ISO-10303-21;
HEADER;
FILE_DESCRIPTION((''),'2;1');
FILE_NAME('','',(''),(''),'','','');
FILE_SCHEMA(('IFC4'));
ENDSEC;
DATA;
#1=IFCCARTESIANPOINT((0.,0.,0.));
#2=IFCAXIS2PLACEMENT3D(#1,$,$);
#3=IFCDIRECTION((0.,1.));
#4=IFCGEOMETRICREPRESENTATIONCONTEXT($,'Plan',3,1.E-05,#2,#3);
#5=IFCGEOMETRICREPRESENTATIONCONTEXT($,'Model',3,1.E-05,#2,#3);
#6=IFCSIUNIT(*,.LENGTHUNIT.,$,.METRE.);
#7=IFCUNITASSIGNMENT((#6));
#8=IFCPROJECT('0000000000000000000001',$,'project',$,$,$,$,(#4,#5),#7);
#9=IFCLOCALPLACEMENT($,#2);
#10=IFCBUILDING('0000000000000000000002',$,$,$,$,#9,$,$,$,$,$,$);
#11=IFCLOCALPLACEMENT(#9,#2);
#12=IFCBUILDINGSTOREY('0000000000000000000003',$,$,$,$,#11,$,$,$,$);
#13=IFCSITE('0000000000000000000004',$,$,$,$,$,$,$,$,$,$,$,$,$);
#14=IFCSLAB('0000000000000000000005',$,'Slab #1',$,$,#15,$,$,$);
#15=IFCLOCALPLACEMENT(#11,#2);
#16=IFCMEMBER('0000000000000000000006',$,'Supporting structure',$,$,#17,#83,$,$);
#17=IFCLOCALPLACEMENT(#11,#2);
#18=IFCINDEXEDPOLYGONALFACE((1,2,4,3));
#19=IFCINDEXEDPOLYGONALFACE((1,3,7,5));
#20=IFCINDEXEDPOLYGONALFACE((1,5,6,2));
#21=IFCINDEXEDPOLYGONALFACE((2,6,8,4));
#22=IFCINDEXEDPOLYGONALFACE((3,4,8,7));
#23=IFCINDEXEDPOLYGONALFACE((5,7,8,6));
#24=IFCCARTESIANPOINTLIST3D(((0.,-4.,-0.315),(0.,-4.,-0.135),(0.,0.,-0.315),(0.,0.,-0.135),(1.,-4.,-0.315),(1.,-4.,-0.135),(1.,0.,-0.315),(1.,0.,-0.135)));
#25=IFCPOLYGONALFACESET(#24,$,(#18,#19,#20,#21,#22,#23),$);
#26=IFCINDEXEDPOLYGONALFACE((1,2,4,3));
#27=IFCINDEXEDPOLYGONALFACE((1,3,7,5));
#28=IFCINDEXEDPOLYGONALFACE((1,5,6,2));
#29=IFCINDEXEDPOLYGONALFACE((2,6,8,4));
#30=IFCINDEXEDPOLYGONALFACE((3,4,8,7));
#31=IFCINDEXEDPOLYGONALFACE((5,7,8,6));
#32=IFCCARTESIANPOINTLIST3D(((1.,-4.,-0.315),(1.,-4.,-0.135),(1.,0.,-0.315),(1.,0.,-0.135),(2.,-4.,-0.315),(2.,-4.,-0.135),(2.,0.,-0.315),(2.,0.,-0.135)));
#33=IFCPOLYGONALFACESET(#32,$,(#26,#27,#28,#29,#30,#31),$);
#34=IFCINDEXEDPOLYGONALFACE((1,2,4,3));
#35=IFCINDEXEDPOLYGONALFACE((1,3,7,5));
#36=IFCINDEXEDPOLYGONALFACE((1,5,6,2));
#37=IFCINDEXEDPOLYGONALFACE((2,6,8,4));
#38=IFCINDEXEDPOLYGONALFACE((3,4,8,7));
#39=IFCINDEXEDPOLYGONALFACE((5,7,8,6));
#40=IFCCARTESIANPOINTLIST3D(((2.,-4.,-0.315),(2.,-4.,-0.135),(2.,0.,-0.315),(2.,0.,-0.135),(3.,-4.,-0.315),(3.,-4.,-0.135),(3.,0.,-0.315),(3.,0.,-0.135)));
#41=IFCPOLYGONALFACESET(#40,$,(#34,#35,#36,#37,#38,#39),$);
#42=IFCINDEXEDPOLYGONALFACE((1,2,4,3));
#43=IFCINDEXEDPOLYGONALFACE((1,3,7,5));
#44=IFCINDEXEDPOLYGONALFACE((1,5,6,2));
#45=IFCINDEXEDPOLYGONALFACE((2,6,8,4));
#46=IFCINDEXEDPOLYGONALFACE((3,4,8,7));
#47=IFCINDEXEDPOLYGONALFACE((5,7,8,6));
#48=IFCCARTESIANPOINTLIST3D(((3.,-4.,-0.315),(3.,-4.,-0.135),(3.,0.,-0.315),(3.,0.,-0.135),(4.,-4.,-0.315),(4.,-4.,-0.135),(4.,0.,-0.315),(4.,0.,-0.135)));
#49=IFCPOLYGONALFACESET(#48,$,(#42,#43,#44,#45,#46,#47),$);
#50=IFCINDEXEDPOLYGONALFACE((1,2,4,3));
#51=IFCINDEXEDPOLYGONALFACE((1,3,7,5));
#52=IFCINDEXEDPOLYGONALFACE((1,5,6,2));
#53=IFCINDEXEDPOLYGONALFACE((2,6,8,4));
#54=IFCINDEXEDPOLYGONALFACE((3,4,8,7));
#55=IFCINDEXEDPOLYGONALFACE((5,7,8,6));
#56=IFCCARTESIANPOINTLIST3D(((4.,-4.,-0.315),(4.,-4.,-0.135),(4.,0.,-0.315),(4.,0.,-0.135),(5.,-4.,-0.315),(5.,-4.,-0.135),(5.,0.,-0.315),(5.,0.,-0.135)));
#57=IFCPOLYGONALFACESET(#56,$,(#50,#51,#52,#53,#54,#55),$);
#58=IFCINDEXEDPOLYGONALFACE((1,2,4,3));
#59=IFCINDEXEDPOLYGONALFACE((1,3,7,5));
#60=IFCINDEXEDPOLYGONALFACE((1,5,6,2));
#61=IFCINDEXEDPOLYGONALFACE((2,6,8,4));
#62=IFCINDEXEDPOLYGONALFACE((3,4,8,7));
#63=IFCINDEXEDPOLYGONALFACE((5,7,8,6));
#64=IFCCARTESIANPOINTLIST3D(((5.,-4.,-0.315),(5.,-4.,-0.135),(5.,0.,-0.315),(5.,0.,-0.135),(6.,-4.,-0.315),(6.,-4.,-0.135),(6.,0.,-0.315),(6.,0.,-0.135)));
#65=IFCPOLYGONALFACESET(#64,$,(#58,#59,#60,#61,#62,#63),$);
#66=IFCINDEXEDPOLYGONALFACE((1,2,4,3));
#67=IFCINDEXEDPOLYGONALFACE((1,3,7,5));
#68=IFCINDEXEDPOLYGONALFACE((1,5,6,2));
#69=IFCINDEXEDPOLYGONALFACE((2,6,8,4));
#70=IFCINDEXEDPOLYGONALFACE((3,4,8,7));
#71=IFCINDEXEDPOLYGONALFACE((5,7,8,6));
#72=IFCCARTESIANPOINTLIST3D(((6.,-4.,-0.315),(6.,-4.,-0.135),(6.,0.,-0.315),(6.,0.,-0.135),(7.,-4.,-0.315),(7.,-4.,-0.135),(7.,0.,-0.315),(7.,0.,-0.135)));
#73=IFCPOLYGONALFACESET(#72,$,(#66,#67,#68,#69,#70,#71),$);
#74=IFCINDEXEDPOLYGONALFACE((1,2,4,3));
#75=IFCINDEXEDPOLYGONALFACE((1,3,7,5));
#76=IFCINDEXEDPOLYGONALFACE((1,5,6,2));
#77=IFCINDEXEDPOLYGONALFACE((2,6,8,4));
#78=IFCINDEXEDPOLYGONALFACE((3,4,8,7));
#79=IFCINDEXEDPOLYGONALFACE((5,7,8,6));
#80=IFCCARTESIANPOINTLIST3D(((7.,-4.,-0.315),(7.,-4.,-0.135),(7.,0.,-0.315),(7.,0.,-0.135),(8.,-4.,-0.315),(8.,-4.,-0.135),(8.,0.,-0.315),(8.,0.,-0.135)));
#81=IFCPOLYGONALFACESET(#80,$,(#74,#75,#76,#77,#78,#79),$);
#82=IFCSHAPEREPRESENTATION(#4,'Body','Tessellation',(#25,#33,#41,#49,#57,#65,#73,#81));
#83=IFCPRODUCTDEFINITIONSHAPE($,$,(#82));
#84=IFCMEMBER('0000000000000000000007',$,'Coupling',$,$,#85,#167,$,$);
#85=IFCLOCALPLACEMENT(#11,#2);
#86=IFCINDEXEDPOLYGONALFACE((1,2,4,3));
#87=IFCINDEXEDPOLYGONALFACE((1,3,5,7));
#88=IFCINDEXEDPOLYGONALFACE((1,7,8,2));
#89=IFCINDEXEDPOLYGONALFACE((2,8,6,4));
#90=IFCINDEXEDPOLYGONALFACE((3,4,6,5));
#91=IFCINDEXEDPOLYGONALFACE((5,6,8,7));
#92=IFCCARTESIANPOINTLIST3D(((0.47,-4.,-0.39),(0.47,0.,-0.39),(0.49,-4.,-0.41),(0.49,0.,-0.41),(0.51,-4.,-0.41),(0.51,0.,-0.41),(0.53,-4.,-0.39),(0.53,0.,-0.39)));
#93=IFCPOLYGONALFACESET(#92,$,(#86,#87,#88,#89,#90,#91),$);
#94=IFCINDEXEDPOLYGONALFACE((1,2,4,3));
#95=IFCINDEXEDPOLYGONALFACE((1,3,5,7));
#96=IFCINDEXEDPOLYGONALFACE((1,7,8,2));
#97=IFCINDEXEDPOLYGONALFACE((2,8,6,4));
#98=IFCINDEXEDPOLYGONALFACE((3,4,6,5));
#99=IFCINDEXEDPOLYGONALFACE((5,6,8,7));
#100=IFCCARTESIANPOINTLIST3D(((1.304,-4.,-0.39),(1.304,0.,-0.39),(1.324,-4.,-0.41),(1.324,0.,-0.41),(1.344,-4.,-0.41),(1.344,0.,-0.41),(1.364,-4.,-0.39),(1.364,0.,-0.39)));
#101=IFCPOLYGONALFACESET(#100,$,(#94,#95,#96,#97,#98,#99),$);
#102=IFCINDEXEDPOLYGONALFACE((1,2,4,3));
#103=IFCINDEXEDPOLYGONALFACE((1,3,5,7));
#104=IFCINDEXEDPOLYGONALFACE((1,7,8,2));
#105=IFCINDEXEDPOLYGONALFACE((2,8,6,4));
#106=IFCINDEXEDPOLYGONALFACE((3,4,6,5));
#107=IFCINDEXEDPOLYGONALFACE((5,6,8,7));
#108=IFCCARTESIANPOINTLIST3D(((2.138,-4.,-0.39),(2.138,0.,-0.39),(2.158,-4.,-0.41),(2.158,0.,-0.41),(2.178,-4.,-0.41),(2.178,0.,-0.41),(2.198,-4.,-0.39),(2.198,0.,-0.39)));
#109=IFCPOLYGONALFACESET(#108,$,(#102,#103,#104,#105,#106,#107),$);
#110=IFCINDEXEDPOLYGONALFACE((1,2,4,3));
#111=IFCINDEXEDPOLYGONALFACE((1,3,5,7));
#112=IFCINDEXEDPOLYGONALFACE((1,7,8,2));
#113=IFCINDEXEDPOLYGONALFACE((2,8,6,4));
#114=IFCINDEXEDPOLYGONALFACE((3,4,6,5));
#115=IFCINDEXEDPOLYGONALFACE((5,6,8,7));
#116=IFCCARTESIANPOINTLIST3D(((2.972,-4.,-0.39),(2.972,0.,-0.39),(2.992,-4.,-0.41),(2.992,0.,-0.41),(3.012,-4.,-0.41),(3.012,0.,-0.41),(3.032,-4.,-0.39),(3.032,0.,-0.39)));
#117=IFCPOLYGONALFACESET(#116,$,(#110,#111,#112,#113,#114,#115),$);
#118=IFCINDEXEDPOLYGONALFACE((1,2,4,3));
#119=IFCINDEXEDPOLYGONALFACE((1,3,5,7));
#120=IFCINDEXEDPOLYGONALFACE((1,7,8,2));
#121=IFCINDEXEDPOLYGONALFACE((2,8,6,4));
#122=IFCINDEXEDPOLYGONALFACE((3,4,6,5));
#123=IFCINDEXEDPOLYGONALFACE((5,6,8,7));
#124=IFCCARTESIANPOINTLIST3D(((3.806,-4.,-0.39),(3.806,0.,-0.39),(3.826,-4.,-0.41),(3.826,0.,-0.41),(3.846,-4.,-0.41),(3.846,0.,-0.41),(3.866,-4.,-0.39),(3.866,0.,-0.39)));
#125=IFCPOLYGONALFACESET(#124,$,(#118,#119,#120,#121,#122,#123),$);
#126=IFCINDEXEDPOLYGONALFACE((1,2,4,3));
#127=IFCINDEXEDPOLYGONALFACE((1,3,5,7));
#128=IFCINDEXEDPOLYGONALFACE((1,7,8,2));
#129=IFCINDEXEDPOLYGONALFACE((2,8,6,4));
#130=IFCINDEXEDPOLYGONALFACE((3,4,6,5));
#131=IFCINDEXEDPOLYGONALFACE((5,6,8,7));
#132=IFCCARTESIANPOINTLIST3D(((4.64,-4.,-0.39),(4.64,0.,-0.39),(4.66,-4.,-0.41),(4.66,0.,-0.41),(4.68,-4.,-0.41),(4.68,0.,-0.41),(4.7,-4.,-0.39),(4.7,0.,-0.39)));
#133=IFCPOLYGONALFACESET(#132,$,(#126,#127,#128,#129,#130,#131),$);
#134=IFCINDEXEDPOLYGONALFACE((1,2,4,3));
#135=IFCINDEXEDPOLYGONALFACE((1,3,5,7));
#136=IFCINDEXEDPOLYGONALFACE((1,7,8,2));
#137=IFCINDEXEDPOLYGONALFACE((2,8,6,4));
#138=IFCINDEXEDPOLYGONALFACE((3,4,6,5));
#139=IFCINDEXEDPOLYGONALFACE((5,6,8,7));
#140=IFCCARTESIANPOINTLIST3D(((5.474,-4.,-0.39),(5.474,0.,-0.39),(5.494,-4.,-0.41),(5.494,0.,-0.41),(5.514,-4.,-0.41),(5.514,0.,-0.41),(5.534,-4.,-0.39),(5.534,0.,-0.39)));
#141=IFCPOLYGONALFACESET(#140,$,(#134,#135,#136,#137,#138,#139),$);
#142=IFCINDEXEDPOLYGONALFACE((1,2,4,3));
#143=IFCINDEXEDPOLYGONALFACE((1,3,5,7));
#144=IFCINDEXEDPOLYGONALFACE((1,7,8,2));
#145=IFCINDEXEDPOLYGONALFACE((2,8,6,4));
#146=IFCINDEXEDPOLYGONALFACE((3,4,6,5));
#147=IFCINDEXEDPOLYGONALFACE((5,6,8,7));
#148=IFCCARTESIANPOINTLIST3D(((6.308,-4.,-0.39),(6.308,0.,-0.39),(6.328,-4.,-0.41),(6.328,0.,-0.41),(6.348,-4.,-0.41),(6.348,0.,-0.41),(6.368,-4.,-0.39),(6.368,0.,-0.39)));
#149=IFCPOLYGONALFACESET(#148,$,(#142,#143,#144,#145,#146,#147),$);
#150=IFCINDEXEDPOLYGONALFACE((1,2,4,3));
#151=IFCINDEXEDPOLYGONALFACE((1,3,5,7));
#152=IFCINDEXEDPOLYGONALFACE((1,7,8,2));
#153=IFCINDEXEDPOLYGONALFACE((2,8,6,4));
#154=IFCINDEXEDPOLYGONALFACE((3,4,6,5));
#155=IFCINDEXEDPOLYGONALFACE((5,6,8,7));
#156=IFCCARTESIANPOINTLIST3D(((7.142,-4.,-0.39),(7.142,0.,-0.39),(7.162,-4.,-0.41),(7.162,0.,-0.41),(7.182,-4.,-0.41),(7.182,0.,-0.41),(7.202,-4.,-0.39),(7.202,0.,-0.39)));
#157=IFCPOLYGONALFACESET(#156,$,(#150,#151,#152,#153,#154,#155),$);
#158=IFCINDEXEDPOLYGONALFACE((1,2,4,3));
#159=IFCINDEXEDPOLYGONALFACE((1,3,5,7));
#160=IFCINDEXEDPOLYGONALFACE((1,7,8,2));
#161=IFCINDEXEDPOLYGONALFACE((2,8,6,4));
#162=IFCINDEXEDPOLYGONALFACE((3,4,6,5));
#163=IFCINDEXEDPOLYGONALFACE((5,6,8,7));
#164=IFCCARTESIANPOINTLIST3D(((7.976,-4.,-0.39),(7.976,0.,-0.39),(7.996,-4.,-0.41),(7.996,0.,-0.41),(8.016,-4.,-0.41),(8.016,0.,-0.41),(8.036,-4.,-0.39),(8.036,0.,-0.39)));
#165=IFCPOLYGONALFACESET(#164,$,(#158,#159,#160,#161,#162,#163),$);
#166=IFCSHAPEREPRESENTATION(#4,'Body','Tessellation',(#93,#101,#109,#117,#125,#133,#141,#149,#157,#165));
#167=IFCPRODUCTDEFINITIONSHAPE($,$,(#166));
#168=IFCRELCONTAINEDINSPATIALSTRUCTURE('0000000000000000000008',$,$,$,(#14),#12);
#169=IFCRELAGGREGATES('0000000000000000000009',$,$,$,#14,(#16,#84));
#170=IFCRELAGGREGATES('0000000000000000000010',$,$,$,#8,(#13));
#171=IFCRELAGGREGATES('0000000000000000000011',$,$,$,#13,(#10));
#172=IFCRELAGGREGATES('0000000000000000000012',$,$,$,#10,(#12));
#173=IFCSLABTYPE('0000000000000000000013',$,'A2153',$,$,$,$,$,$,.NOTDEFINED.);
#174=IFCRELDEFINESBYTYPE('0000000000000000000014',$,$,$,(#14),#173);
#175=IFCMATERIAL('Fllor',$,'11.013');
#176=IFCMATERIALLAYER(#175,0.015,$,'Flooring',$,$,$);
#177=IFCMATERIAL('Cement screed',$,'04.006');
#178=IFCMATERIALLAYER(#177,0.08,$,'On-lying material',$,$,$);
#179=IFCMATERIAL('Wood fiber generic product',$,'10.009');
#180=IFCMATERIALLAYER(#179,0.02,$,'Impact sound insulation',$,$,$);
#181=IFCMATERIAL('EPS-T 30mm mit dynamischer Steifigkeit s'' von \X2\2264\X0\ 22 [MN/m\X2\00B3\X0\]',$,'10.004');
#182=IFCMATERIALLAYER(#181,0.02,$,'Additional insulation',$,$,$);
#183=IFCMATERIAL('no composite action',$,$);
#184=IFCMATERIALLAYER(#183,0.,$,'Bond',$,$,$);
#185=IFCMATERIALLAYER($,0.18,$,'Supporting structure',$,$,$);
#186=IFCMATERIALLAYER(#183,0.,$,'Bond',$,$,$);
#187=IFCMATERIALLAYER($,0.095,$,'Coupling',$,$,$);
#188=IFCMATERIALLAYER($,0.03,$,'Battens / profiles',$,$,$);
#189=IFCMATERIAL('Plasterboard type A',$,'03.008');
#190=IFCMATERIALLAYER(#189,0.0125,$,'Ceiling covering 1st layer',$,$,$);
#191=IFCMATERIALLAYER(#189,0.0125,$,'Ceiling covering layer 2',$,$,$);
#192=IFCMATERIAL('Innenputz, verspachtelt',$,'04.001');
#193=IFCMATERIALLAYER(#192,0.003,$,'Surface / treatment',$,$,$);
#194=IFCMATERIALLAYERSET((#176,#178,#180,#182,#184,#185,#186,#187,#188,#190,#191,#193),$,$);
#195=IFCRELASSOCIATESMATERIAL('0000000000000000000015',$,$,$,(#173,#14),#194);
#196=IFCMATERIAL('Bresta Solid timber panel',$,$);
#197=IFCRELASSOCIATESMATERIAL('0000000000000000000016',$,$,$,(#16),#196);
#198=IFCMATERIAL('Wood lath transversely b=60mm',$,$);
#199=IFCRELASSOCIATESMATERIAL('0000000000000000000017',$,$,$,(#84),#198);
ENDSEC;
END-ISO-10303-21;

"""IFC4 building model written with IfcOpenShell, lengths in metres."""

from ifc_helpers import new_model, si_unit, direction, frame, frame_2d, origin, place, context, project, spatial, polyline, rectangle, outline, extrude, material, layer, layer_set, type_object, element, aggregate, save


model = new_model("IFC4")

# Units and contexts
plan_context = context("Plan", 3, precision=1e-05, world=origin(), true_north=direction((0.0, 1.0)))
model_context = context("Model", 3, precision=1e-05, world=origin(), true_north=direction((0.0, 1.0)))
ifc_project = project(units=[si_unit("LENGTHUNIT", "METRE")], contexts=[plan_context, model_context])

# Site, building, storey
site = spatial("IfcSite", under=ifc_project)
building_placement = place(None, origin())
building = spatial("IfcBuilding", under=site, at=building_placement)
storey_placement = place(building_placement, origin())
storey = spatial("IfcBuildingStorey", under=building, at=storey_placement)

# Slab, members
ifc_material_1 = material(Name="Fllor", Category="11.013")
ifc_layer_1 = layer(ifc_material_1, 0.015, Name="Flooring")
ifc_material_2 = material(Name="Cement screed", Category="04.006")
ifc_layer_2 = layer(ifc_material_2, 0.08, Name="On-lying material")
ifc_material_3 = material(Name="Wood fiber generic product", Category="10.009")
ifc_layer_3 = layer(ifc_material_3, 0.02, Name="Impact sound insulation")
ifc_material_4 = material(Name="EPS-T 30mm mit dynamischer Steifigkeit s' von ≤ 22 [MN/m³]", Category="10.004")
ifc_layer_4 = layer(ifc_material_4, 0.02, Name="Additional insulation")
ifc_material_5 = material(Name="no composite action")
ifc_layer_5 = layer(ifc_material_5, 0.0, Name="Bond")
ifc_layer_6 = layer(None, 0.18, Name="Supporting structure")
ifc_layer_7 = layer(ifc_material_5, 0.0, Name="Bond")
ifc_layer_8 = layer(None, 0.095, Name="Coupling")
ifc_layer_9 = layer(None, 0.03, Name="Battens / profiles")
ifc_material_6 = material(Name="Plasterboard type A", Category="03.008")
ifc_layer_10 = layer(ifc_material_6, 0.0125, Name="Ceiling covering 1st layer")
ifc_layer_11 = layer(ifc_material_6, 0.0125, Name="Ceiling covering layer 2")
ifc_material_7 = material(Name="Innenputz, verspachtelt", Category="04.001")
ifc_layer_12 = layer(ifc_material_7, 0.003, Name="Surface / treatment")
ifc_layer_set = layer_set([ifc_layer_1, ifc_layer_2, ifc_layer_3, ifc_layer_4, ifc_layer_5, ifc_layer_6, ifc_layer_7, ifc_layer_8, ifc_layer_9, ifc_layer_10, ifc_layer_11, ifc_layer_12])
slab_type = type_object("IfcSlabType", Name="A2153", PredefinedType="NOTDEFINED", material=ifc_layer_set)
slab_placement = place(None, frame((0.0, 0.0, 0.0), z_axis=(0.0, 0.0, -1.0), x_axis=(1.0, 0.0, 0.0)))
slab = element("IfcSlab", 1, at=slab_placement, inside=storey, type_object=slab_type, material=ifc_layer_set, Name="Slab #1")
ifc_material_8 = material(Name="Bresta Solid timber panel")
member_1_placement = place(slab_placement, origin())
member_1 = element("IfcMember", 2, at=member_1_placement, material=ifc_material_8, Name="Supporting structure", context=plan_context, shape_type="SweptSolid", body=[
    extrude(rectangle(XDim=1.0, YDim=0.18, at=frame_2d((0.5, 0.09), x_axis=(1.0, 0.0))), frame((0.0, 4.0, 0.135), z_axis=(0.0, -1.0, 0.0), x_axis=(1.0, 0.0, 0.0)), (0.0, 0.0, 1.0), 4.0),
    extrude(rectangle(XDim=1.0, YDim=0.18, at=frame_2d((0.5, 0.09), x_axis=(1.0, 0.0))), frame((1.0, 4.0, 0.135), z_axis=(0.0, -1.0, 0.0), x_axis=(1.0, 0.0, 0.0)), (0.0, 0.0, 1.0), 4.0),
    extrude(rectangle(XDim=1.0, YDim=0.18, at=frame_2d((0.5, 0.09), x_axis=(1.0, 0.0))), frame((2.0, 4.0, 0.135), z_axis=(0.0, -1.0, 0.0), x_axis=(1.0, 0.0, 0.0)), (0.0, 0.0, 1.0), 4.0),
    extrude(rectangle(XDim=1.0, YDim=0.18, at=frame_2d((0.5, 0.09), x_axis=(1.0, 0.0))), frame((3.0, 4.0, 0.135), z_axis=(0.0, -1.0, 0.0), x_axis=(1.0, 0.0, 0.0)), (0.0, 0.0, 1.0), 4.0),
    extrude(rectangle(XDim=1.0, YDim=0.18, at=frame_2d((0.5, 0.09), x_axis=(1.0, 0.0))), frame((4.0, 4.0, 0.135), z_axis=(0.0, -1.0, 0.0), x_axis=(1.0, 0.0, 0.0)), (0.0, 0.0, 1.0), 4.0),
    extrude(rectangle(XDim=1.0, YDim=0.18, at=frame_2d((0.5, 0.09), x_axis=(1.0, 0.0))), frame((5.0, 4.0, 0.135), z_axis=(0.0, -1.0, 0.0), x_axis=(1.0, 0.0, 0.0)), (0.0, 0.0, 1.0), 4.0),
    extrude(rectangle(XDim=1.0, YDim=0.18, at=frame_2d((0.5, 0.09), x_axis=(1.0, 0.0))), frame((6.0, 4.0, 0.135), z_axis=(0.0, -1.0, 0.0), x_axis=(1.0, 0.0, 0.0)), (0.0, 0.0, 1.0), 4.0),
    extrude(rectangle(XDim=1.0, YDim=0.18, at=frame_2d((0.5, 0.09), x_axis=(1.0, 0.0))), frame((7.0, 4.0, 0.135), z_axis=(0.0, -1.0, 0.0), x_axis=(1.0, 0.0, 0.0)), (0.0, 0.0, 1.0), 4.0),
])
ifc_material_9 = material(Name="Wood lath transversely b=60mm")
member_2_placement = place(slab_placement, origin())
member_2 = element("IfcMember", 3, at=member_2_placement, material=ifc_material_9, Name="Coupling", context=plan_context, shape_type="SweptSolid", body=[
    extrude(outline(polyline([(0.0, 0.0), (0.06, 0.0), (0.04, 0.02), (0.02, 0.02), (0.0, 0.0)])), frame((0.47, 4.0, 0.39), z_axis=(0.0, -1.0, 0.0), x_axis=(1.0, 0.0, 0.0)), (0.0, 0.0, 1.0), 4.0),
    extrude(outline(polyline([(0.0, 0.0), (0.06, 0.0), (0.04, 0.02), (0.02, 0.02), (0.0, 0.0)])), frame((1.304, 4.0, 0.39), z_axis=(0.0, -1.0, 0.0), x_axis=(1.0, 0.0, 0.0)), (0.0, 0.0, 1.0), 4.0),
    extrude(outline(polyline([(0.0, 0.0), (0.06, 0.0), (0.04, 0.02), (0.02, 0.02), (0.0, 0.0)])), frame((2.138, 4.0, 0.39), z_axis=(0.0, -1.0, 0.0), x_axis=(1.0, 0.0, 0.0)), (0.0, 0.0, 1.0), 4.0),
    extrude(outline(polyline([(0.0, 0.0), (0.06, 0.0), (0.04, 0.02), (0.02, 0.02), (0.0, 0.0)])), frame((2.972, 4.0, 0.39), z_axis=(0.0, -1.0, 0.0), x_axis=(1.0, 0.0, 0.0)), (0.0, 0.0, 1.0), 4.0),
    extrude(outline(polyline([(0.0, 0.0), (0.06, 0.0), (0.04, 0.02), (0.02, 0.02), (0.0, 0.0)])), frame((3.806, 4.0, 0.39), z_axis=(0.0, -1.0, 0.0), x_axis=(1.0, 0.0, 0.0)), (0.0, 0.0, 1.0), 4.0),
    extrude(outline(polyline([(0.0, 0.0), (0.06, 0.0), (0.04, 0.02), (0.02, 0.02), (0.0, 0.0)])), frame((4.64, 4.0, 0.39), z_axis=(0.0, -1.0, 0.0), x_axis=(1.0, 0.0, 0.0)), (0.0, 0.0, 1.0), 4.0),
    extrude(outline(polyline([(0.0, 0.0), (0.06, 0.0), (0.04, 0.02), (0.02, 0.02), (0.0, 0.0)])), frame((5.474, 4.0, 0.39), z_axis=(0.0, -1.0, 0.0), x_axis=(1.0, 0.0, 0.0)), (0.0, 0.0, 1.0), 4.0),
    extrude(outline(polyline([(0.0, 0.0), (0.06, 0.0), (0.04, 0.02), (0.02, 0.02), (0.0, 0.0)])), frame((6.308, 4.0, 0.39), z_axis=(0.0, -1.0, 0.0), x_axis=(1.0, 0.0, 0.0)), (0.0, 0.0, 1.0), 4.0),
    extrude(outline(polyline([(0.0, 0.0), (0.06, 0.0), (0.04, 0.02), (0.02, 0.02), (0.0, 0.0)])), frame((7.142, 4.0, 0.39), z_axis=(0.0, -1.0, 0.0), x_axis=(1.0, 0.0, 0.0)), (0.0, 0.0, 1.0), 4.0),
    extrude(outline(polyline([(0.0, 0.0), (0.06, 0.0), (0.04, 0.02), (0.02, 0.02), (0.0, 0.0)])), frame((7.976, 4.0, 0.39), z_axis=(0.0, -1.0, 0.0), x_axis=(1.0, 0.0, 0.0)), (0.0, 0.0, 1.0), 4.0),
])
aggregate(slab, [member_1, member_2])

save(model, "model.ifc")
